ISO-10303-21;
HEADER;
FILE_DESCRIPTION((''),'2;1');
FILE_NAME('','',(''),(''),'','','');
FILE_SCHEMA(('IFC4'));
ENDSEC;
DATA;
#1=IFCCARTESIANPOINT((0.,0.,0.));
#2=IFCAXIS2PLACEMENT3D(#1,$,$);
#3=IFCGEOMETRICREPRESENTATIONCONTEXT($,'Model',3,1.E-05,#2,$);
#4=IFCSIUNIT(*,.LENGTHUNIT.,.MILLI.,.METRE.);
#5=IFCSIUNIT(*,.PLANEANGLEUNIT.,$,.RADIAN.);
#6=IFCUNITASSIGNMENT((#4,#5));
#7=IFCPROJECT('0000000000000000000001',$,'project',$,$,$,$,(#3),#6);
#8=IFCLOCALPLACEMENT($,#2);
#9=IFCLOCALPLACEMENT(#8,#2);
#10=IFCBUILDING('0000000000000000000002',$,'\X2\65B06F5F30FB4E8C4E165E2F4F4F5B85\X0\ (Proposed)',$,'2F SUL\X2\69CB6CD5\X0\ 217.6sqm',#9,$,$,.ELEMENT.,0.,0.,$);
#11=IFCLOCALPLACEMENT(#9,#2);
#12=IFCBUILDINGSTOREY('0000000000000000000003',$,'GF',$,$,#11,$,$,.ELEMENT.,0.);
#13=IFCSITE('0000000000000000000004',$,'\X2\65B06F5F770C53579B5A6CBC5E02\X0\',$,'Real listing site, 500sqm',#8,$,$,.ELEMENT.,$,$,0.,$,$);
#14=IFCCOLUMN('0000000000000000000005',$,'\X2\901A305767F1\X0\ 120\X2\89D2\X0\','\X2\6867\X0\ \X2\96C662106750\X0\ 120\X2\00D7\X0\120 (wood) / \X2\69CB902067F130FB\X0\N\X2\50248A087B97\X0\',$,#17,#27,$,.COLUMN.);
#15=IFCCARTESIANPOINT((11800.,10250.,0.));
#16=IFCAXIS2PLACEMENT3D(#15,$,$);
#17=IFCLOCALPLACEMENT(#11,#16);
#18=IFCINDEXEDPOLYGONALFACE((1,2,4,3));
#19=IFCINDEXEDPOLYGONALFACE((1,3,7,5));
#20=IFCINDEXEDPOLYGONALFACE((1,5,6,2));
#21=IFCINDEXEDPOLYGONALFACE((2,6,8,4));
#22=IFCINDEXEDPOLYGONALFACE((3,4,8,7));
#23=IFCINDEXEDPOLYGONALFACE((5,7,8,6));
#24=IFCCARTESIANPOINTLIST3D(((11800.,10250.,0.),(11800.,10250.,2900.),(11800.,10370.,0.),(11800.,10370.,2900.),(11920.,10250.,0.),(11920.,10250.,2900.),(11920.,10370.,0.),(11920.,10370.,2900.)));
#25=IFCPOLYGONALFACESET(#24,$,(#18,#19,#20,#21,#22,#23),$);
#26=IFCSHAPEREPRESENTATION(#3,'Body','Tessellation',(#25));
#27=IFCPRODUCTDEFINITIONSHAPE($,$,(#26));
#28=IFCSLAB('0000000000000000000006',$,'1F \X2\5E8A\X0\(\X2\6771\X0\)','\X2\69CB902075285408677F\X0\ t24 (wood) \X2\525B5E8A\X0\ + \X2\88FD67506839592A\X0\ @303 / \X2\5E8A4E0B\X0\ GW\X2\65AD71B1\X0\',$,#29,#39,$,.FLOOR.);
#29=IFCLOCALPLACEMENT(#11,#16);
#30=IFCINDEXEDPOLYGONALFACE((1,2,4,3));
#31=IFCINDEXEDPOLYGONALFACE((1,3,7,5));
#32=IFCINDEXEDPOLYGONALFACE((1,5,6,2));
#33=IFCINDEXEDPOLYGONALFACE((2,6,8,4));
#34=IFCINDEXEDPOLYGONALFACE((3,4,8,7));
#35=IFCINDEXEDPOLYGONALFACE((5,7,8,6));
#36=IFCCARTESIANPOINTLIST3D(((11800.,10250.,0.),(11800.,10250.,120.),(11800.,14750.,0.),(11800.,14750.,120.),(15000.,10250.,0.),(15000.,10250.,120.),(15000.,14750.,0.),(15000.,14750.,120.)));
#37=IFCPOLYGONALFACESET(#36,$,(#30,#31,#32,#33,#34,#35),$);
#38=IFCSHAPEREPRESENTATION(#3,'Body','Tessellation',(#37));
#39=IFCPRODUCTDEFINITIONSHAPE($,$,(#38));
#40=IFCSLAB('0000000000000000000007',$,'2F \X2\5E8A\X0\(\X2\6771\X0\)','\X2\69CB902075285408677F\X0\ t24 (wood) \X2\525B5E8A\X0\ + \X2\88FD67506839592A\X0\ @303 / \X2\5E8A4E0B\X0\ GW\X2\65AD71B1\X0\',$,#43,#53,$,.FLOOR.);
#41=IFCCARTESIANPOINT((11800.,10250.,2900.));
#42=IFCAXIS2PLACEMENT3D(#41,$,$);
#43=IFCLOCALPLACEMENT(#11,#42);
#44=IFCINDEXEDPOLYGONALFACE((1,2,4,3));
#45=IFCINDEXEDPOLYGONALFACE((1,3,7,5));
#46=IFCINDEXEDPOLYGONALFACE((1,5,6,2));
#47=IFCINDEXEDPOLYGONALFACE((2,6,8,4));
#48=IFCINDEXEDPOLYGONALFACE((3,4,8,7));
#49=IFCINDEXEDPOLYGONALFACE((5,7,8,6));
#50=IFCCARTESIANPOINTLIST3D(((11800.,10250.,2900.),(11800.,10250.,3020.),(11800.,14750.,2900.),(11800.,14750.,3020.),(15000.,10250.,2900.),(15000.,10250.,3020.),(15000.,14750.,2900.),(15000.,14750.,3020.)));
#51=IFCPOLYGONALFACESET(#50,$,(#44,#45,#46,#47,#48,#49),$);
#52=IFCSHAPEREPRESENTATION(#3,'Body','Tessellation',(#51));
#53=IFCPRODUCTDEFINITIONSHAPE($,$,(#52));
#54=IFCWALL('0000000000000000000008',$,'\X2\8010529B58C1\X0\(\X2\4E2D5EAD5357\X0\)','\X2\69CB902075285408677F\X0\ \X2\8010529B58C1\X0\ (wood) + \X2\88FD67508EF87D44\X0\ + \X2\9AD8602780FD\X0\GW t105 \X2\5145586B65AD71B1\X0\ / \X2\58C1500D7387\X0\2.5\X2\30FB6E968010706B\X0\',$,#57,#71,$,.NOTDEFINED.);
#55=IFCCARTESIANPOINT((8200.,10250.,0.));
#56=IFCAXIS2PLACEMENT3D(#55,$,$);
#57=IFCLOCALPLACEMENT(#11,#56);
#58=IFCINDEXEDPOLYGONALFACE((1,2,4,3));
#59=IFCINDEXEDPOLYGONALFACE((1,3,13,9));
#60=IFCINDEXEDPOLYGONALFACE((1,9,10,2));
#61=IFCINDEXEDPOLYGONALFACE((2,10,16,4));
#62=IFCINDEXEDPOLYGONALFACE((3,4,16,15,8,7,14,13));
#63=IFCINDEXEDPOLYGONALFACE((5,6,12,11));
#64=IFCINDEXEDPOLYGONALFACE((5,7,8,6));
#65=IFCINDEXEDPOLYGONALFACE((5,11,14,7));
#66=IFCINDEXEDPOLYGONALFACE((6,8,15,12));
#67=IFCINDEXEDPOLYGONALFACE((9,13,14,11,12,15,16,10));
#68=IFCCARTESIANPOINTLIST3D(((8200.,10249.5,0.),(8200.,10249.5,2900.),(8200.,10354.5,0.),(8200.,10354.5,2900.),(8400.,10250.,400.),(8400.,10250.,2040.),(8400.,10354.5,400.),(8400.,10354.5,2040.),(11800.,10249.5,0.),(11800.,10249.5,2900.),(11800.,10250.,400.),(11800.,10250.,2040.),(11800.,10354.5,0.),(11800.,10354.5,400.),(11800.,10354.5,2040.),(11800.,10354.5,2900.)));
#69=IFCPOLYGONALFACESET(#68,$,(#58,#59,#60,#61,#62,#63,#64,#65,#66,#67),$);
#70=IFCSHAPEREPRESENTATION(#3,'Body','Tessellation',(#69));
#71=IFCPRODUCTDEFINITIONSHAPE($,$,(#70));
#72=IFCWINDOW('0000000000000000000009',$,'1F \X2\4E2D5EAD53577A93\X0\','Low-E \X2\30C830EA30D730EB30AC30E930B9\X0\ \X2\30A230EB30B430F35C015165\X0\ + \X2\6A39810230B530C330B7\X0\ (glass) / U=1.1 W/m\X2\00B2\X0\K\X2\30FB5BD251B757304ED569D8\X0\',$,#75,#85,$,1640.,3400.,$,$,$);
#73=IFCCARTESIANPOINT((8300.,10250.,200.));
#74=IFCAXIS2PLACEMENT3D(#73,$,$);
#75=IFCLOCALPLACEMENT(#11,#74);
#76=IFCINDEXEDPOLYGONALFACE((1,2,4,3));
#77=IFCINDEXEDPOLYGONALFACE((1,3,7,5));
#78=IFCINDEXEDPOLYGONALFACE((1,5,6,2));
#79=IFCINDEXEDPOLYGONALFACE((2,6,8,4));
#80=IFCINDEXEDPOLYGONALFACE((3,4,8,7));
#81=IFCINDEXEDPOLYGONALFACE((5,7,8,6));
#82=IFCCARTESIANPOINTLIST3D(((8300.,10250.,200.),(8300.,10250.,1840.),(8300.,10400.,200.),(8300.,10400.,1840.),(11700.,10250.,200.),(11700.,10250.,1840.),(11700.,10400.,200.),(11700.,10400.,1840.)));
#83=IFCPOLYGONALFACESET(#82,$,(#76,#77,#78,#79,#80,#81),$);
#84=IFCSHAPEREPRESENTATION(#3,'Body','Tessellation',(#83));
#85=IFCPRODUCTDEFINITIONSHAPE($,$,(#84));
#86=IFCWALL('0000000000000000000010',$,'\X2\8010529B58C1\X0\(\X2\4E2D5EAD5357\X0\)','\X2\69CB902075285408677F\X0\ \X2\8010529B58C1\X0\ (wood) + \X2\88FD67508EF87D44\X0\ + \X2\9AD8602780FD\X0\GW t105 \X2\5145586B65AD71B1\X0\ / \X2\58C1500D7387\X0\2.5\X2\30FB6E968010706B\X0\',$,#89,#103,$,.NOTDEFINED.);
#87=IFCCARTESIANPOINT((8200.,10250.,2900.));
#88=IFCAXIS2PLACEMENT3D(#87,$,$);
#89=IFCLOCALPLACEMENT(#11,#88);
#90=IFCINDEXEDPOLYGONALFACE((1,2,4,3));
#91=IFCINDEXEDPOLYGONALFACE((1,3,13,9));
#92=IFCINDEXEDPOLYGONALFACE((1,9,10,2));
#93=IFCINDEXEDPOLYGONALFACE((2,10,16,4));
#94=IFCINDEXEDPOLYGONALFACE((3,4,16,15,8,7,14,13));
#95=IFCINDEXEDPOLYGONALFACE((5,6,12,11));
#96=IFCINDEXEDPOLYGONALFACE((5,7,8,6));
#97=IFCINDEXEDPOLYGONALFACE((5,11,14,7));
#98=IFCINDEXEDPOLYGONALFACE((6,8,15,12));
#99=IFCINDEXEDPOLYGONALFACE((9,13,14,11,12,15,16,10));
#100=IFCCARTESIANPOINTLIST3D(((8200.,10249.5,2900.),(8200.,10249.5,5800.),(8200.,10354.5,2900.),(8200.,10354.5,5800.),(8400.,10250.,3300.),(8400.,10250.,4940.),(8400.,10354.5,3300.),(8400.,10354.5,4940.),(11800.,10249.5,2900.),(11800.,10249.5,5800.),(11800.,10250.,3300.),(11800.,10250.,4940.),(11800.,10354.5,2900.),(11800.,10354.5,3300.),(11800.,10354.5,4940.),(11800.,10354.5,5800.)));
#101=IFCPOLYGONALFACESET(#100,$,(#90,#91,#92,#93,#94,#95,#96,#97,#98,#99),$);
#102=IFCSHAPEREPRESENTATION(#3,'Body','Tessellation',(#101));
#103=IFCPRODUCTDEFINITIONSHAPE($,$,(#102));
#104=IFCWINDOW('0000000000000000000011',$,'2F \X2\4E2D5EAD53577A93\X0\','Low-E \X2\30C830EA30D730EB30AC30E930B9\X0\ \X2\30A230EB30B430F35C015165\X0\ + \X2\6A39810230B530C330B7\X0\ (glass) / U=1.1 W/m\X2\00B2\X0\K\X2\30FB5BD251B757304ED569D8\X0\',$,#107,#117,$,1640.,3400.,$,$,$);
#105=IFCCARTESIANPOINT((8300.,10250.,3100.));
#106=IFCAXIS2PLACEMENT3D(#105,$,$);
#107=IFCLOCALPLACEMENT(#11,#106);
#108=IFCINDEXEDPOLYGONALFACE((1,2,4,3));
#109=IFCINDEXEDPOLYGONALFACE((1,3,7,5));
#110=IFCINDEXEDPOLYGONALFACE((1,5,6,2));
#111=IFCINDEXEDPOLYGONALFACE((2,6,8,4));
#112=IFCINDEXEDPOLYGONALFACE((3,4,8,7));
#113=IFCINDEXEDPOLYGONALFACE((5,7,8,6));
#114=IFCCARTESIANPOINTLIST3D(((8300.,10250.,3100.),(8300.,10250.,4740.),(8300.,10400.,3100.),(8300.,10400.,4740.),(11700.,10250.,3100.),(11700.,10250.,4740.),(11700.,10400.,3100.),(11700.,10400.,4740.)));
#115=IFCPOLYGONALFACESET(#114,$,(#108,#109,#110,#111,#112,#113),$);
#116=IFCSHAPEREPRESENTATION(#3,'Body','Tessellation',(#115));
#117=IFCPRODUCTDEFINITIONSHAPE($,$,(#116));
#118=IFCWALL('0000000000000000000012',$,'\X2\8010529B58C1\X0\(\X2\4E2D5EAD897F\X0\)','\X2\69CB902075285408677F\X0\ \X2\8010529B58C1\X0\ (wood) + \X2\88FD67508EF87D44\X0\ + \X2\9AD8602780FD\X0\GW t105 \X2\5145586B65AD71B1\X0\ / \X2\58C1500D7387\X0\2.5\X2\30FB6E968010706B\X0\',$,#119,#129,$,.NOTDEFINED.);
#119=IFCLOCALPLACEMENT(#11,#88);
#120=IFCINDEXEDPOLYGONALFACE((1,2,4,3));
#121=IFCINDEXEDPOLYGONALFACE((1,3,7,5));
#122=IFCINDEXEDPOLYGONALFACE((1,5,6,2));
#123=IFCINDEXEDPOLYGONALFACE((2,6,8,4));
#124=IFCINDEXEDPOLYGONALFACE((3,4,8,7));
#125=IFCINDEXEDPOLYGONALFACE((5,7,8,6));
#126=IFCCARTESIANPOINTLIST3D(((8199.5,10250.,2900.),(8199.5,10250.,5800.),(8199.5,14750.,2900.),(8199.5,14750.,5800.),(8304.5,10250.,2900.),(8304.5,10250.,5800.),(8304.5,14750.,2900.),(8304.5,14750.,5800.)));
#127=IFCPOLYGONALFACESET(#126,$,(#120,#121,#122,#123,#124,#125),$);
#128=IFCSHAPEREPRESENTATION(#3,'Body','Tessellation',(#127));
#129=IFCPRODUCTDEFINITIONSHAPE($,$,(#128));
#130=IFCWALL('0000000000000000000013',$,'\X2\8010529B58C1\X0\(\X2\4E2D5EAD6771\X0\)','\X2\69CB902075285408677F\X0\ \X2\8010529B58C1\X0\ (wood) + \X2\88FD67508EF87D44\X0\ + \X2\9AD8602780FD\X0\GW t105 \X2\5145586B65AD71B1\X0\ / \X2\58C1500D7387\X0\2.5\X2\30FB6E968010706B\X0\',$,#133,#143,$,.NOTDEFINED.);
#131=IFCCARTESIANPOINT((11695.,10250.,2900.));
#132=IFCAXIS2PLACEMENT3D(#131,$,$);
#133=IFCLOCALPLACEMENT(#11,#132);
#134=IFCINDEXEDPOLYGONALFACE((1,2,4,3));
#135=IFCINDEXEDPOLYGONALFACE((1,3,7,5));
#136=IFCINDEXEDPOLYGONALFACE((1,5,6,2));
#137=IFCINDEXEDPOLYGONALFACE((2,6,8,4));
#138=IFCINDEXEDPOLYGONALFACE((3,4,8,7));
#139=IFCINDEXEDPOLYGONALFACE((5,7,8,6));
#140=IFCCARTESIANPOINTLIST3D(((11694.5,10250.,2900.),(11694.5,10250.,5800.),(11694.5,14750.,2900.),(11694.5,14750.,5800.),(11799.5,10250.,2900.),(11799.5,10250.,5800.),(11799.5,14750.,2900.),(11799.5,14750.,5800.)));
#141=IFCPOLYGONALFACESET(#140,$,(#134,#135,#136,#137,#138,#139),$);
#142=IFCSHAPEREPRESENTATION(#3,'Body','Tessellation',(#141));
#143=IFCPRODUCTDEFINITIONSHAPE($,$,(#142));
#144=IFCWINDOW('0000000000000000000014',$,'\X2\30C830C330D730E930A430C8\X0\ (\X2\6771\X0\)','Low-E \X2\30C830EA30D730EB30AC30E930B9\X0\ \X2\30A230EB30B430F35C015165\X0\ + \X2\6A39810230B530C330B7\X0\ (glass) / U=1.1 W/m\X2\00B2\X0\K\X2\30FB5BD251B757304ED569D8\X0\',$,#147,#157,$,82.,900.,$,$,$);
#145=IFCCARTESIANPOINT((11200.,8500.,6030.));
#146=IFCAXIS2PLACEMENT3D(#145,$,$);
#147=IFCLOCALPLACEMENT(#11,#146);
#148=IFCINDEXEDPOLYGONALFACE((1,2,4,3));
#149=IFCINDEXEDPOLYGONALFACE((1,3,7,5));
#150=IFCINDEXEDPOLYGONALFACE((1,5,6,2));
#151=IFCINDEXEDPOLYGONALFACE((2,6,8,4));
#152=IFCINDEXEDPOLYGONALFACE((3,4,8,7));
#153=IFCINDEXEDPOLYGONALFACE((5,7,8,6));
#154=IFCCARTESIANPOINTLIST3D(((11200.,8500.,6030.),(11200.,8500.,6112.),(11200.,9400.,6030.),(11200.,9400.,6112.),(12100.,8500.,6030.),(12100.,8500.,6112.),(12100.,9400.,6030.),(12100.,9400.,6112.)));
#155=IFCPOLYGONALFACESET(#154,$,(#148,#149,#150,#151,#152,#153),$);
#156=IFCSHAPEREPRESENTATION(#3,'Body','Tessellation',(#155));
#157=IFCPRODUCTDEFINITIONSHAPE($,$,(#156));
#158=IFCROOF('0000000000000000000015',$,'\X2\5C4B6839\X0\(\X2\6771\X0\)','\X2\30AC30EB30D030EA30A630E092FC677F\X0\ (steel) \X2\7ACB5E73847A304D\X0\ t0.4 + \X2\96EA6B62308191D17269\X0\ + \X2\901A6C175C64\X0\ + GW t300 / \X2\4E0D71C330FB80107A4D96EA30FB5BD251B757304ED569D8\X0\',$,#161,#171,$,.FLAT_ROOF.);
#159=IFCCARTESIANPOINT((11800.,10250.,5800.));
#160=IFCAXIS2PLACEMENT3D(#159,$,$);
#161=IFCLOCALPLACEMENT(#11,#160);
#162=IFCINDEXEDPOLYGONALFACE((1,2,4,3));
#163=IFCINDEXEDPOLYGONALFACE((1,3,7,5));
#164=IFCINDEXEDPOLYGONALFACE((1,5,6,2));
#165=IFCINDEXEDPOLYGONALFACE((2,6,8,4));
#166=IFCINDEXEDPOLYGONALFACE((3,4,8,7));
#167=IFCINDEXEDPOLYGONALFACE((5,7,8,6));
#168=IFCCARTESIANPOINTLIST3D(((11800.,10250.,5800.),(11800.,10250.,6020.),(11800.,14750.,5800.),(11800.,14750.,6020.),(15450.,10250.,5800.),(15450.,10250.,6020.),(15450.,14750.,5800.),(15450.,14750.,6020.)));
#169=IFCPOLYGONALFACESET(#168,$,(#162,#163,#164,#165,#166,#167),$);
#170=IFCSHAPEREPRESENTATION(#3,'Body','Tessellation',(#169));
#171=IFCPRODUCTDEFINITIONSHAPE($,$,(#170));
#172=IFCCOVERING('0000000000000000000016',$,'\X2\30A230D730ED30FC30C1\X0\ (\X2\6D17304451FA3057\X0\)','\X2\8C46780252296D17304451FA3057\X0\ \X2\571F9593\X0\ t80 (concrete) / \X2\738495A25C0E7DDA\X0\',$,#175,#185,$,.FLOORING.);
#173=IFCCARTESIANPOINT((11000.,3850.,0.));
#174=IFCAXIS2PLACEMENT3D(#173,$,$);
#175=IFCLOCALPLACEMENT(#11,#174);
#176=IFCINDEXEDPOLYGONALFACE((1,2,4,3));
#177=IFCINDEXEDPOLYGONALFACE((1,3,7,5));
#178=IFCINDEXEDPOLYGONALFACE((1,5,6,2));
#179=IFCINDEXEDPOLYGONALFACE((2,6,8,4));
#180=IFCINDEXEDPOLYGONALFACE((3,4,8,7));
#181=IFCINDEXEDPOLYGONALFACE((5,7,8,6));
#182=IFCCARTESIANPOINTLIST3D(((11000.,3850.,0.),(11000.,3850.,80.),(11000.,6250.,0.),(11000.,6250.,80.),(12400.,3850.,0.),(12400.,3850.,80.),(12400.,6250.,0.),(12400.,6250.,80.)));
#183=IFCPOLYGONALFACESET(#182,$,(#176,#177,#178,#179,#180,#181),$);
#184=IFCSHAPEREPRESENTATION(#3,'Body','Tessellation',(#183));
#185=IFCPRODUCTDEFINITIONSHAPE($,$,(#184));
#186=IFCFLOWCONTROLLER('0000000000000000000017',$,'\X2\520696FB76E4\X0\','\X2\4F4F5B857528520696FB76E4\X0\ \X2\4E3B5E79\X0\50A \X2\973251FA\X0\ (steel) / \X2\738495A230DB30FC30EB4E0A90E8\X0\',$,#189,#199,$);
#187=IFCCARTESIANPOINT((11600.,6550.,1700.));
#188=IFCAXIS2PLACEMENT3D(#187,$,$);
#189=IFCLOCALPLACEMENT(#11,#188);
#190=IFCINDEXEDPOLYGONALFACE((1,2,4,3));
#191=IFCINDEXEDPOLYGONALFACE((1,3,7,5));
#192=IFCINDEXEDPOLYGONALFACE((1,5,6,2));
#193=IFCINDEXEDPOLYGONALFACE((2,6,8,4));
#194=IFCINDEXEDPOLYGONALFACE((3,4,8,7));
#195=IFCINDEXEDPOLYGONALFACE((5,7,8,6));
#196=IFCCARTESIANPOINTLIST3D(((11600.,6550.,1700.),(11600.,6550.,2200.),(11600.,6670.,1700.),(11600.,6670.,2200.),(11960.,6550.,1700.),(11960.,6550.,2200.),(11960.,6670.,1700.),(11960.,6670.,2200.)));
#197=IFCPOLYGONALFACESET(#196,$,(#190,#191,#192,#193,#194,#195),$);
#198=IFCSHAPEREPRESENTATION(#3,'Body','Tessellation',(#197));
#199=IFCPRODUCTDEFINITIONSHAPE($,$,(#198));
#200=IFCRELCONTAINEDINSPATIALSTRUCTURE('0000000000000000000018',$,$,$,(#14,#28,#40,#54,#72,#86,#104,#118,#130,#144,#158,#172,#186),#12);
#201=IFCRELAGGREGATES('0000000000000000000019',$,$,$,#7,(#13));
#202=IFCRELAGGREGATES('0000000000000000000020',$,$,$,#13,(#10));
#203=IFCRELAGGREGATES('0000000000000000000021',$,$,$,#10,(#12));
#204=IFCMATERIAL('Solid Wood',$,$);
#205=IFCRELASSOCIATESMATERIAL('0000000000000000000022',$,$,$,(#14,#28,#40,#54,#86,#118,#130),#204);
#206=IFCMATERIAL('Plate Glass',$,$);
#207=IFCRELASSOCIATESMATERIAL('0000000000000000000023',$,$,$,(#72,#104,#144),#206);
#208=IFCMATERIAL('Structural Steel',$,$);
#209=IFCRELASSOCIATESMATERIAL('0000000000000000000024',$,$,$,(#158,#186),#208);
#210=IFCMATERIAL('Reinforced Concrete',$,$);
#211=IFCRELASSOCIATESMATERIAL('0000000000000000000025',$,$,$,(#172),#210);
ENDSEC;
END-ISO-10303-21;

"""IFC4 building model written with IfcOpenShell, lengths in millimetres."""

from ifc_helpers import new_model, si_unit, frame, frame_2d, origin, place, context, project, spatial, rectangle, extrude, material, element, fill, save


model = new_model("IFC4")

# Units and contexts
model_context = context("Model", 3, precision=1e-05, world=origin())
ifc_project = project(units=[si_unit("LENGTHUNIT", "METRE", prefix="MILLI"), si_unit("PLANEANGLEUNIT", "RADIAN")], contexts=[model_context])

# Site, building, storey
site_placement = place(None, origin())
site = spatial("IfcSite", under=ifc_project, at=site_placement, Name="新潟県南魚沼市", ObjectType="Real listing site, 500sqm", CompositionType="ELEMENT", RefElevation=0.0)
building_placement = place(site_placement, origin())
building = spatial("IfcBuilding", under=site, at=building_placement, Name="新潟・二世帯住宅 (Proposed)", ObjectType="2F SUL構法 217.6sqm", CompositionType="ELEMENT", ElevationOfRefHeight=0.0, ElevationOfTerrain=0.0)
storey_placement = place(building_placement, origin())
storey = spatial("IfcBuildingStorey", under=building, at=storey_placement, Name="GF", CompositionType="ELEMENT", Elevation=0.0)

# Column
ifc_material_1 = material(Name="Solid Wood")
column_1_placement = place(storey_placement, frame((11800.0, 10250.0, 0.0)))
element("IfcColumn", 1, at=column_1_placement, inside=storey, material=ifc_material_1, Name="通し柱 120角", Description="桧 集成材 120×120 (wood) / 構造柱・N値計算", PredefinedType="COLUMN", context=model_context, shape_type="SweptSolid", body=[
    extrude(rectangle(XDim=120.0, YDim=120.0, at=frame_2d((60.0, 60.0))), frame((11800.0, 10250.0, 0.0)), (0.0, 0.0, 1.0), 2900.0),
])

# Slabs
slab_1_placement = place(storey_placement, frame((11800.0, 10250.0, 0.0)))
element("IfcSlab", 2, at=slab_1_placement, inside=storey, material=ifc_material_1, Name="1F 床(東)", Description="構造用合板 t24 (wood) 剛床 + 製材根太 @303 / 床下 GW断熱", PredefinedType="FLOOR", context=model_context, shape_type="SweptSolid", body=[
    extrude(rectangle(XDim=3200.0, YDim=4500.0, at=frame_2d((1600.0, 2250.0))), frame((11800.0, 10250.0, 0.0)), (0.0, 0.0, 1.0), 120.0),
])
slab_2_placement = place(storey_placement, frame((11800.0, 10250.0, 2900.0)))
element("IfcSlab", 3, at=slab_2_placement, inside=storey, material=ifc_material_1, Name="2F 床(東)", Description="構造用合板 t24 (wood) 剛床 + 製材根太 @303 / 床下 GW断熱", PredefinedType="FLOOR", context=model_context, shape_type="SweptSolid", body=[
    extrude(rectangle(XDim=3200.0, YDim=4500.0, at=frame_2d((1600.0, 2250.0))), frame((11800.0, 10250.0, 2900.0)), (0.0, 0.0, 1.0), 120.0),
])

# Wall, opening, window
wall_1_placement = place(storey_placement, frame((8200.0, 10250.0, 0.0)))
wall_1 = element("IfcWall", 4, at=wall_1_placement, inside=storey, material=ifc_material_1, Name="耐力壁(中庭南)", Description="構造用合板 耐力壁 (wood) + 製材軸組 + 高性能GW t105 充填断熱 / 壁倍率2.5・準耐火", PredefinedType="NOTDEFINED", context=model_context, shape_type="SweptSolid", body=[
    extrude(rectangle(XDim=3600.0, YDim=105.0, at=frame_2d((1800.0, 52.0))), frame((8200.0, 10250.0, 0.0)), (0.0, 0.0, 1.0), 2900.0),
])
opening_1_placement = place(storey_placement, frame((8300.0, 10250.0, 200.0)))
opening_1 = element("IfcOpeningElement", 5, at=opening_1_placement, cuts=wall_1, PredefinedType="NOTDEFINED", context=model_context, shape_type="SweptSolid", body=[
    extrude(rectangle(XDim=3400.0, YDim=150.0, at=frame_2d((1700.0, 75.0))), frame((8300.0, 10250.0, 200.0)), (0.0, 0.0, 1.0), 1640.0),
])
ifc_material_2 = material(Name="Plate Glass")
window_1_placement = place(storey_placement, frame((8300.0, 10250.0, 200.0)))
window_1 = element("IfcWindow", 6, at=window_1_placement, inside=storey, material=ifc_material_2, Name="1F 中庭南窓", Description="Low-E トリプルガラス アルゴン封入 + 樹脂サッシ (glass) / U=1.1 W/m²K・寒冷地仕様", OverallHeight=1640.0, OverallWidth=3400.0, context=model_context, shape_type="SweptSolid", body=[
    extrude(rectangle(XDim=3400.0, YDim=150.0, at=frame_2d((1700.0, 75.0))), frame((8300.0, 10250.0, 200.0)), (0.0, 0.0, 1.0), 1640.0),
])
fill(opening_1, window_1)

# Wall, opening, window
wall_2_placement = place(storey_placement, frame((8200.0, 10250.0, 2900.0)))
wall_2 = element("IfcWall", 7, at=wall_2_placement, inside=storey, material=ifc_material_1, Name="耐力壁(中庭南)", Description="構造用合板 耐力壁 (wood) + 製材軸組 + 高性能GW t105 充填断熱 / 壁倍率2.5・準耐火", PredefinedType="NOTDEFINED", context=model_context, shape_type="SweptSolid", body=[
    extrude(rectangle(XDim=3600.0, YDim=105.0, at=frame_2d((1800.0, 52.0))), frame((8200.0, 10250.0, 2900.0)), (0.0, 0.0, 1.0), 2900.0),
])
opening_2_placement = place(storey_placement, frame((8300.0, 10250.0, 3100.0)))
opening_2 = element("IfcOpeningElement", 8, at=opening_2_placement, cuts=wall_2, PredefinedType="NOTDEFINED", context=model_context, shape_type="SweptSolid", body=[
    extrude(rectangle(XDim=3400.0, YDim=150.0, at=frame_2d((1700.0, 75.0))), frame((8300.0, 10250.0, 3100.0)), (0.0, 0.0, 1.0), 1640.0),
])
window_2_placement = place(storey_placement, frame((8300.0, 10250.0, 3100.0)))
window_2 = element("IfcWindow", 9, at=window_2_placement, inside=storey, material=ifc_material_2, Name="2F 中庭南窓", Description="Low-E トリプルガラス アルゴン封入 + 樹脂サッシ (glass) / U=1.1 W/m²K・寒冷地仕様", OverallHeight=1640.0, OverallWidth=3400.0, context=model_context, shape_type="SweptSolid", body=[
    extrude(rectangle(XDim=3400.0, YDim=150.0, at=frame_2d((1700.0, 75.0))), frame((8300.0, 10250.0, 3100.0)), (0.0, 0.0, 1.0), 1640.0),
])
fill(opening_2, window_2)

# Walls
wall_3_placement = place(storey_placement, frame((8200.0, 10250.0, 2900.0)))
element("IfcWall", 10, at=wall_3_placement, inside=storey, material=ifc_material_1, Name="耐力壁(中庭西)", Description="構造用合板 耐力壁 (wood) + 製材軸組 + 高性能GW t105 充填断熱 / 壁倍率2.5・準耐火", PredefinedType="NOTDEFINED", context=model_context, shape_type="SweptSolid", body=[
    extrude(rectangle(XDim=105.0, YDim=4500.0, at=frame_2d((52.0, 2250.0))), frame((8200.0, 10250.0, 2900.0)), (0.0, 0.0, 1.0), 2900.0),
])
wall_4_placement = place(storey_placement, frame((11695.0, 10250.0, 2900.0)))
element("IfcWall", 11, at=wall_4_placement, inside=storey, material=ifc_material_1, Name="耐力壁(中庭東)", Description="構造用合板 耐力壁 (wood) + 製材軸組 + 高性能GW t105 充填断熱 / 壁倍率2.5・準耐火", PredefinedType="NOTDEFINED", context=model_context, shape_type="SweptSolid", body=[
    extrude(rectangle(XDim=105.0, YDim=4500.0, at=frame_2d((52.0, 2250.0))), frame((11695.0, 10250.0, 2900.0)), (0.0, 0.0, 1.0), 2900.0),
])

# Window
window_3_placement = place(storey_placement, frame((11200.0, 8500.0, 6030.0)))
element("IfcWindow", 12, at=window_3_placement, inside=storey, material=ifc_material_2, Name="トップライト (東)", Description="Low-E トリプルガラス アルゴン封入 + 樹脂サッシ (glass) / U=1.1 W/m²K・寒冷地仕様", OverallHeight=82.0, OverallWidth=900.0, context=model_context, shape_type="SweptSolid", body=[
    extrude(rectangle(XDim=900.0, YDim=900.0, at=frame_2d((450.0, 450.0))), frame((11200.0, 8500.0, 6030.0)), (0.0, 0.0, 1.0), 82.0),
])

# Roof
ifc_material_3 = material(Name="Structural Steel")
for number, where, name in (
    (13, (11800.0, 10250.0, 5800.0), "屋根(東)"),
):
    element("IfcRoof", number, at=place(storey_placement, frame(where)), inside=storey, material=ifc_material_3, Name=name, Description="ガルバリウム鋼板 (steel) 立平葺き t0.4 + 雪止め金物 + 通気層 + GW t300 / 不燃・耐積雪・寒冷地仕様", PredefinedType="FLAT_ROOF", context=model_context, shape_type="SweptSolid", body=[
        extrude(rectangle(XDim=3650.0, YDim=4500.0, at=frame_2d((1825.0, 2250.0))), frame((11800.0, 10250.0, 5800.0)), (0.0, 0.0, 1.0), 220.0),
    ])

# Covering
ifc_material_4 = material(Name="Reinforced Concrete")
covering_placement = place(storey_placement, frame((11000.0, 3850.0, 0.0)))
element("IfcCovering", 14, at=covering_placement, inside=storey, material=ifc_material_4, Name="アプローチ (洗い出し)", Description="豆砂利洗い出し 土間 t80 (concrete) / 玄関導線", PredefinedType="FLOORING", context=model_context, shape_type="SweptSolid", body=[
    extrude(rectangle(XDim=1400.0, YDim=2400.0, at=frame_2d((700.0, 1200.0))), frame((11000.0, 3850.0, 0.0)), (0.0, 0.0, 1.0), 80.0),
])

# Flow controller
flow_controller_placement = place(storey_placement, frame((11600.0, 6550.0, 1700.0)))
element("IfcFlowController", 15, at=flow_controller_placement, inside=storey, material=ifc_material_3, Name="分電盤", Description="住宅用分電盤 主幹50A 露出 (steel) / 玄関ホール上部", context=model_context, shape_type="SweptSolid", body=[
    extrude(rectangle(XDim=360.0, YDim=120.0, at=frame_2d((180.0, 60.0))), frame((11600.0, 6550.0, 1700.0)), (0.0, 0.0, 1.0), 500.0),
])

save(model, "model.ifc")
